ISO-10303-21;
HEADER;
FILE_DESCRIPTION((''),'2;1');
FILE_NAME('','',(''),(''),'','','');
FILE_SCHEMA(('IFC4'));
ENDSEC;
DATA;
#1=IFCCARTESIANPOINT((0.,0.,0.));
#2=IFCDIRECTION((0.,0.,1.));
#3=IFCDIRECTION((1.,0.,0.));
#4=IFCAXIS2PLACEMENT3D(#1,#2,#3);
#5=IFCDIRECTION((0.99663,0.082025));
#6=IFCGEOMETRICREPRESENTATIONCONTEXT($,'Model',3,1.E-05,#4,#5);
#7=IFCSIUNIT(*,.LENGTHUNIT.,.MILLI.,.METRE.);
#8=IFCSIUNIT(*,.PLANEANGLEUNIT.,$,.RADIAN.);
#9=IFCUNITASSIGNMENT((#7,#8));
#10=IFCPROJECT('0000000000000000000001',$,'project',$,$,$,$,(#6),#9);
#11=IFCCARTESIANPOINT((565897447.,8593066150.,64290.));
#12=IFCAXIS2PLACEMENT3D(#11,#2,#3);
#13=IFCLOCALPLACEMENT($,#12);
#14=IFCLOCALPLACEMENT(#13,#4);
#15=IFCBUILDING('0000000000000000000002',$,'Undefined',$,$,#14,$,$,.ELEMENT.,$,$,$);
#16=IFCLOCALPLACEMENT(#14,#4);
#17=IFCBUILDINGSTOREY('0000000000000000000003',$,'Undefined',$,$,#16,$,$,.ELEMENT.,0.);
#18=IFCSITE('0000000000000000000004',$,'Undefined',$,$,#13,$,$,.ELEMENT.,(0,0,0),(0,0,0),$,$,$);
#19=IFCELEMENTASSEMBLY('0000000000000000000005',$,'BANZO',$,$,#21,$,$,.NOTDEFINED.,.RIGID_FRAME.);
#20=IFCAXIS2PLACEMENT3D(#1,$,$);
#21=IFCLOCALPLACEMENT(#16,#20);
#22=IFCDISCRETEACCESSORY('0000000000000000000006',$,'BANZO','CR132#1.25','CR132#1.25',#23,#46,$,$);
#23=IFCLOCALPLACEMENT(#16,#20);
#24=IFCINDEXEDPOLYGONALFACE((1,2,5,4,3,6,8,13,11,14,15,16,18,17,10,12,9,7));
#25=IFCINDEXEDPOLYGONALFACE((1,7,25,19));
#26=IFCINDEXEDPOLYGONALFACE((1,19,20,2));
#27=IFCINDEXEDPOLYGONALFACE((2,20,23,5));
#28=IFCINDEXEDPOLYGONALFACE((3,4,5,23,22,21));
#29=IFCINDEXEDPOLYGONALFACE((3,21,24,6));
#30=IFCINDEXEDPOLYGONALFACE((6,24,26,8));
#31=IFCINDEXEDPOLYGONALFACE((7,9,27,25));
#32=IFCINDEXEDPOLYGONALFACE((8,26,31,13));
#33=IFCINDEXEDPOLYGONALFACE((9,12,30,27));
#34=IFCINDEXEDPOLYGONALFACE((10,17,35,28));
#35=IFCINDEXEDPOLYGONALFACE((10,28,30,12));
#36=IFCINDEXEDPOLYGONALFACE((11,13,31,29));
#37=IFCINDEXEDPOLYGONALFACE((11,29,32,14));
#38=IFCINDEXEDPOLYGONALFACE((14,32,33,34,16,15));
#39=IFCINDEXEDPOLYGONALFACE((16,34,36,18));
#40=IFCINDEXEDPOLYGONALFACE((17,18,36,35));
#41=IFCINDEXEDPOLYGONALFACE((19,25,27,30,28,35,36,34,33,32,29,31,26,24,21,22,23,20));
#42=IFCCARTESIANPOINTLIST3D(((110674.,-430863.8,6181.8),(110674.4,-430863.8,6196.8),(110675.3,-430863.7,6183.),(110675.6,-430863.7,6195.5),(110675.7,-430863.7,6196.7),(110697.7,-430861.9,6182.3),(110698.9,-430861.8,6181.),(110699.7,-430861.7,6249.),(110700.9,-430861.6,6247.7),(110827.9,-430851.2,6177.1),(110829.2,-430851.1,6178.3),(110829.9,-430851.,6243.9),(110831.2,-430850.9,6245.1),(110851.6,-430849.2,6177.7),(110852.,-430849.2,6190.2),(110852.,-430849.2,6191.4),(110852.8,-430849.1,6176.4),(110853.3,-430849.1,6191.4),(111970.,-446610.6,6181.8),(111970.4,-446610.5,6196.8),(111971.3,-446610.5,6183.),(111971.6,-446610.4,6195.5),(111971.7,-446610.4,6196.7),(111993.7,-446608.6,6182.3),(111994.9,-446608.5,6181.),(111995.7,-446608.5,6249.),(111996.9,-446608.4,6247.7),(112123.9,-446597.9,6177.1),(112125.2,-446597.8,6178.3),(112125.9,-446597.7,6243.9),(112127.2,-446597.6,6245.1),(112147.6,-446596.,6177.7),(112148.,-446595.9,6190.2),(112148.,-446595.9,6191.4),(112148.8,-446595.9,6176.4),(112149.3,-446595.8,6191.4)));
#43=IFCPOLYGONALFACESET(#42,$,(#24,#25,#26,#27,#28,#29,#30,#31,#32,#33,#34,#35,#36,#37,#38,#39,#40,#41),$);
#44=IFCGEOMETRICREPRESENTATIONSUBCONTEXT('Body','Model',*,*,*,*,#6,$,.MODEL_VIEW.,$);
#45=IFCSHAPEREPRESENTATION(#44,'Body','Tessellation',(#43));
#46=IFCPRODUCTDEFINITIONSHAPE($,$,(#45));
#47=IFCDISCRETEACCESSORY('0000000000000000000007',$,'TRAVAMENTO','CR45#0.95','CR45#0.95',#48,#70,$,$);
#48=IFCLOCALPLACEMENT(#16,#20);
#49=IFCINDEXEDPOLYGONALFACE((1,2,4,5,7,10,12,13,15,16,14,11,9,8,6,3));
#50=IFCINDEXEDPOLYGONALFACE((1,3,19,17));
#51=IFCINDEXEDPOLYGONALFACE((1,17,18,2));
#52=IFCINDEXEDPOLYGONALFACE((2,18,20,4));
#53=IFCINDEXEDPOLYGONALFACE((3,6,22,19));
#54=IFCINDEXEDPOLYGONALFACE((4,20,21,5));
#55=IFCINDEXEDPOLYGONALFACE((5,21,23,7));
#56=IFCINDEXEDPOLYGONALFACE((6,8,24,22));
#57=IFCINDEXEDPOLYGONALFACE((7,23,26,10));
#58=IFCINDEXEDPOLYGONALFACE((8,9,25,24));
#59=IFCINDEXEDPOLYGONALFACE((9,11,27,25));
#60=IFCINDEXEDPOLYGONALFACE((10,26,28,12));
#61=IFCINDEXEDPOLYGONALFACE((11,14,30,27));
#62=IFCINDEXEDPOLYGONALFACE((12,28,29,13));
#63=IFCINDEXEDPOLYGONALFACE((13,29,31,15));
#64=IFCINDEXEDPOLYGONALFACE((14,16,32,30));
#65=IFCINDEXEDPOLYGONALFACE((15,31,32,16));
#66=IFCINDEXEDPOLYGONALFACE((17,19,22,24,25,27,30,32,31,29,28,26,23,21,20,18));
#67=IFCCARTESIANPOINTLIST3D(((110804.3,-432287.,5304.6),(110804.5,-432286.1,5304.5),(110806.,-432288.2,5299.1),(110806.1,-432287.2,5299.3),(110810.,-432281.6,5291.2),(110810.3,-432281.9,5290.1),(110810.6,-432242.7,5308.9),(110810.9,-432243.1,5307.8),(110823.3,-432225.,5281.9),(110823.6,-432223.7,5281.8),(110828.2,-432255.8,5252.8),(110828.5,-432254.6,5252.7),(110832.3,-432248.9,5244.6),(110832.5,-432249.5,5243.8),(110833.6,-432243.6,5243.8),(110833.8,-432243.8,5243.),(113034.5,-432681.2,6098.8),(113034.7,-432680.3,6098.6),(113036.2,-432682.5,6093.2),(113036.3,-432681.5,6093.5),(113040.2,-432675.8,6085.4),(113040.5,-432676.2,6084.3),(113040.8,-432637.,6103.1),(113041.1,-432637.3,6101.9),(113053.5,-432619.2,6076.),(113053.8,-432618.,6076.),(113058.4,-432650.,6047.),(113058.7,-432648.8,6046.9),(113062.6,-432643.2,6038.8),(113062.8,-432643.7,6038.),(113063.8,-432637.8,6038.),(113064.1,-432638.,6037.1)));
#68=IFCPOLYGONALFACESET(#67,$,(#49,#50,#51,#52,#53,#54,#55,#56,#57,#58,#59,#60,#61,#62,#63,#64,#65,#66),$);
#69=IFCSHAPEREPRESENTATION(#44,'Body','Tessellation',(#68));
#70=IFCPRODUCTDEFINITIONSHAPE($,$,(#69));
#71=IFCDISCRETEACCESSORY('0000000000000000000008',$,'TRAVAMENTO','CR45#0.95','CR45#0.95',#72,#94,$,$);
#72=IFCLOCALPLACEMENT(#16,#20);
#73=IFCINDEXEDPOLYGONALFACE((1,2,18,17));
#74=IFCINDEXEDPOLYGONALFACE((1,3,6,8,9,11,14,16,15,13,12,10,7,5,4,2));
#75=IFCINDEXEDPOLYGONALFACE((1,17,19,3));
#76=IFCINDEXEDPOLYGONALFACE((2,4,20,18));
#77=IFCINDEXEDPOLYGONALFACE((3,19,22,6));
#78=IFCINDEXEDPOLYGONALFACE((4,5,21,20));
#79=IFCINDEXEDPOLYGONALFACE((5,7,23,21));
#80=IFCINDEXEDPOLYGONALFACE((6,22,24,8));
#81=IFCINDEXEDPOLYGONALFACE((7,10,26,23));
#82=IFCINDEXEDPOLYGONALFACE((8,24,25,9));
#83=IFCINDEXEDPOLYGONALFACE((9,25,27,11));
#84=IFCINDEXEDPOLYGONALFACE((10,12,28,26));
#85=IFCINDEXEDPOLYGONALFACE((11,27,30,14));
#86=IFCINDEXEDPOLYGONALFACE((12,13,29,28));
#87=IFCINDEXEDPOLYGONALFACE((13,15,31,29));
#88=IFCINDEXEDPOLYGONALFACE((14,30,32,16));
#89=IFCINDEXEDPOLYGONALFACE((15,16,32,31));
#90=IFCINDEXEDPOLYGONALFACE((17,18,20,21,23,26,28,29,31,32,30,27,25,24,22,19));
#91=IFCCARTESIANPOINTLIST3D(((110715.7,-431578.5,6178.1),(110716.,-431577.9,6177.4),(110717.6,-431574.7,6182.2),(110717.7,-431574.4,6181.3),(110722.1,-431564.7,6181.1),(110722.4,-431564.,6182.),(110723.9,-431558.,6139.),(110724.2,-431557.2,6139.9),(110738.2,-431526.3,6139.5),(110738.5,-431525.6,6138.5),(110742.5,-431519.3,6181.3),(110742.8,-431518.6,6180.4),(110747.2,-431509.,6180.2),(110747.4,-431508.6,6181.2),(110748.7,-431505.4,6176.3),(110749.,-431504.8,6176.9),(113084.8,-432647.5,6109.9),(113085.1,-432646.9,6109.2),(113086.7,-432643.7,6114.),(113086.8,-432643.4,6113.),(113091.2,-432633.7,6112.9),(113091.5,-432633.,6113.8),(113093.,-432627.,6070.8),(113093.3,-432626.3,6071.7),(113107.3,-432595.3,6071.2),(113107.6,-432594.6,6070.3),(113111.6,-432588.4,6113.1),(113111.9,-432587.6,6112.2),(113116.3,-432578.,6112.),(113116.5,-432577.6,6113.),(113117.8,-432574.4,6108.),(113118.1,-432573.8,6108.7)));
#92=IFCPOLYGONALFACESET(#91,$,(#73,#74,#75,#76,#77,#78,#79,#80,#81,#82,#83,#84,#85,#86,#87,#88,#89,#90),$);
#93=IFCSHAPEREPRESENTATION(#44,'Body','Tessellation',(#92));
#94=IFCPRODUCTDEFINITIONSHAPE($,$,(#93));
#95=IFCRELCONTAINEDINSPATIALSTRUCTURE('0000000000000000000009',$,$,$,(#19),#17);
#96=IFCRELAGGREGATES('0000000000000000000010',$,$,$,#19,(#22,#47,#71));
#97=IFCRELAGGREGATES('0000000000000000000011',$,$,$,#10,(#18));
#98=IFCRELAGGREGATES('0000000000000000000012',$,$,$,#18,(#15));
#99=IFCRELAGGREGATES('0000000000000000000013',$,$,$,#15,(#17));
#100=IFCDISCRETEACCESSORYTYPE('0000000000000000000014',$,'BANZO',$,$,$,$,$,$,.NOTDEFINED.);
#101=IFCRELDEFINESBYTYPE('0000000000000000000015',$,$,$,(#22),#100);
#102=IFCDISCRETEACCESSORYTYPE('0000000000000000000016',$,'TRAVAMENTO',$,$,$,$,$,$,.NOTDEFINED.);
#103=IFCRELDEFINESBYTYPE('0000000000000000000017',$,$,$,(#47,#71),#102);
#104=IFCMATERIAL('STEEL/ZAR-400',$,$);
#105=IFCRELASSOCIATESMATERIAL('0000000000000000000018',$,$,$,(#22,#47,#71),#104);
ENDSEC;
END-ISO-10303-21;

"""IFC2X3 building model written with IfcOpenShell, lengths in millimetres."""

from ifc_helpers import new_model, si_unit, direction, frame, origin_with_axes, place, context, subcontext, project, spatial, polyline, outline, extrude, material, type_object, element, aggregate, save


model = new_model("IFC2X3")

# Units and contexts
model_context = context("Model", 3, precision=1e-05, world=origin_with_axes(), true_north=direction((0.99663, 0.082025)))
body_context = subcontext(model_context, "Body", "Model", "MODEL_VIEW")
ifc_project = project(units=[si_unit("LENGTHUNIT", "METRE", prefix="MILLI"), si_unit("PLANEANGLEUNIT", "RADIAN")], contexts=[model_context])

# Site, building, storey
site_placement = place(None, frame((565897447.0, 8593066150.0, 64290.0), z_axis=(0.0, 0.0, 1.0), x_axis=(1.0, 0.0, 0.0)))
site = spatial("IfcSite", under=ifc_project, at=site_placement, Name="Undefined", CompositionType="ELEMENT", RefLatitude=(0, 0, 0), RefLongitude=(0, 0, 0))
building_placement = place(site_placement, origin_with_axes())
building = spatial("IfcBuilding", under=site, at=building_placement, Name="Undefined", CompositionType="ELEMENT")
storey_placement = place(building_placement, origin_with_axes())
storey = spatial("IfcBuildingStorey", under=building, at=storey_placement, Name="Undefined", CompositionType="ELEMENT", Elevation=0.0)

# Shared definitions
ifc_material_1 = material(Name="STEEL/ZAR-400")

# Element assembly, discrete accessories
assembly_1_placement = place(storey_placement, origin_with_axes())
assembly_1 = element("IfcElementAssembly", 1, at=assembly_1_placement, inside=storey, Name="BANZO", AssemblyPlace="NOTDEFINED", PredefinedType="RIGID_FRAME")
discrete_accessory_type_1 = type_object("IfcDiscreteAccessoryType", Name="BANZO")
discrete_accessory_1_placement = place(assembly_1_placement, frame((110764.4, -430856.4, 6213.1), z_axis=(0.029885, 0.00246, 0.99955), x_axis=(0.082025, -0.99663, 0.0)))
discrete_accessory_1 = element("IfcDiscreteAccessory", 2, at=discrete_accessory_1_placement, type_object=discrete_accessory_type_1, material=ifc_material_1, Name="BANZO", Description="CR132#1.25", ObjectType="CR132#1.25", context=body_context, shape_type="SweptSolid", body=[
    extrude(outline(polyline([(-64.7, 32.7), (-64.7, -34.0), (-89.7, -34.0), (-89.7, -19.0), (-88.5, -19.0), (-88.5, -20.3), (-88.5, -32.8), (-66.0, -32.8), (-66.0, 34.0), (66.0, 34.0), (66.0, -32.7), (88.5, -32.7), (88.5, -20.2), (88.5, -19.0), (89.7, -19.0), (89.7, -34.0), (64.7, -34.0), (64.7, 32.8), (-64.7, 32.7)])), frame((15800.0, 0.0, 0.0), z_axis=(-1.0, 0.0, 0.0), x_axis=(0.0, -1.0, 0.0)), (0.0, 0.0, 1.0), 15800.0),
])
discrete_accessory_type_2 = type_object("IfcDiscreteAccessoryType", Name="TRAVAMENTO")
discrete_accessory_2_placement = place(assembly_1_placement, frame((110818.3, -432250.9, 5283.1), z_axis=(-0.05151, 0.82934, 0.556366), x_axis=(0.929259, -0.164269, 0.330898)))
discrete_accessory_2 = element("IfcDiscreteAccessory", 3, at=discrete_accessory_2_placement, type_object=discrete_accessory_type_2, material=ifc_material_1, Name="TRAVAMENTO", Description="CR45#0.95", ObjectType="CR45#0.95", context=body_context, shape_type="SweptSolid", body=[
    extrude(outline(polyline([(-35.5, -20.5), (-24.9, -20.5), (-17.4, 21.5), (18.1, 21.5), (25.6, -20.5), (36.2, -20.5), (40.1, -16.6), (40.8, -17.3), (36.6, -21.5), (24.8, -21.5), (17.3, 20.5), (-16.6, 20.5), (-24.1, -21.5), (-35.9, -21.5), (-40.1, -17.3), (-39.4, -16.6), (-35.5, -20.5)])), frame((2400.0, 0.0, 0.0), z_axis=(-1.0, 0.0, 0.0), x_axis=(0.0, -1.0, 0.0)), (0.0, 0.0, 1.0), 2400.0),
])
discrete_accessory_3_placement = place(assembly_1_placement, frame((110731.7, -431542.0, 6160.2), z_axis=(-0.029887, -0.002459, -0.99955), x_axis=(0.911186, -0.411159, -0.026233)))
discrete_accessory_3 = element("IfcDiscreteAccessory", 4, at=discrete_accessory_3_placement, type_object=discrete_accessory_type_2, material=ifc_material_1, Name="TRAVAMENTO", Description="CR45#0.95", ObjectType="CR45#0.95", context=body_context, shape_type="SweptSolid", body=[
    extrude(outline(polyline([(-35.5, -20.5), (-24.9, -20.5), (-17.4, 21.5), (18.1, 21.5), (25.6, -20.5), (36.2, -20.5), (40.1, -16.6), (40.8, -17.3), (36.6, -21.5), (24.8, -21.5), (17.3, 20.5), (-16.6, 20.5), (-24.1, -21.5), (-35.9, -21.5), (-40.1, -17.3), (-39.4, -16.6), (-35.5, -20.5)])), frame((2600.0, 0.0, 0.0), z_axis=(-1.0, 0.0, 0.0), x_axis=(0.0, -1.0, 0.0)), (0.0, 0.0, 1.0), 2600.0),
])
aggregate(assembly_1, [discrete_accessory_1, discrete_accessory_2, discrete_accessory_3])

save(model, "model.ifc")
